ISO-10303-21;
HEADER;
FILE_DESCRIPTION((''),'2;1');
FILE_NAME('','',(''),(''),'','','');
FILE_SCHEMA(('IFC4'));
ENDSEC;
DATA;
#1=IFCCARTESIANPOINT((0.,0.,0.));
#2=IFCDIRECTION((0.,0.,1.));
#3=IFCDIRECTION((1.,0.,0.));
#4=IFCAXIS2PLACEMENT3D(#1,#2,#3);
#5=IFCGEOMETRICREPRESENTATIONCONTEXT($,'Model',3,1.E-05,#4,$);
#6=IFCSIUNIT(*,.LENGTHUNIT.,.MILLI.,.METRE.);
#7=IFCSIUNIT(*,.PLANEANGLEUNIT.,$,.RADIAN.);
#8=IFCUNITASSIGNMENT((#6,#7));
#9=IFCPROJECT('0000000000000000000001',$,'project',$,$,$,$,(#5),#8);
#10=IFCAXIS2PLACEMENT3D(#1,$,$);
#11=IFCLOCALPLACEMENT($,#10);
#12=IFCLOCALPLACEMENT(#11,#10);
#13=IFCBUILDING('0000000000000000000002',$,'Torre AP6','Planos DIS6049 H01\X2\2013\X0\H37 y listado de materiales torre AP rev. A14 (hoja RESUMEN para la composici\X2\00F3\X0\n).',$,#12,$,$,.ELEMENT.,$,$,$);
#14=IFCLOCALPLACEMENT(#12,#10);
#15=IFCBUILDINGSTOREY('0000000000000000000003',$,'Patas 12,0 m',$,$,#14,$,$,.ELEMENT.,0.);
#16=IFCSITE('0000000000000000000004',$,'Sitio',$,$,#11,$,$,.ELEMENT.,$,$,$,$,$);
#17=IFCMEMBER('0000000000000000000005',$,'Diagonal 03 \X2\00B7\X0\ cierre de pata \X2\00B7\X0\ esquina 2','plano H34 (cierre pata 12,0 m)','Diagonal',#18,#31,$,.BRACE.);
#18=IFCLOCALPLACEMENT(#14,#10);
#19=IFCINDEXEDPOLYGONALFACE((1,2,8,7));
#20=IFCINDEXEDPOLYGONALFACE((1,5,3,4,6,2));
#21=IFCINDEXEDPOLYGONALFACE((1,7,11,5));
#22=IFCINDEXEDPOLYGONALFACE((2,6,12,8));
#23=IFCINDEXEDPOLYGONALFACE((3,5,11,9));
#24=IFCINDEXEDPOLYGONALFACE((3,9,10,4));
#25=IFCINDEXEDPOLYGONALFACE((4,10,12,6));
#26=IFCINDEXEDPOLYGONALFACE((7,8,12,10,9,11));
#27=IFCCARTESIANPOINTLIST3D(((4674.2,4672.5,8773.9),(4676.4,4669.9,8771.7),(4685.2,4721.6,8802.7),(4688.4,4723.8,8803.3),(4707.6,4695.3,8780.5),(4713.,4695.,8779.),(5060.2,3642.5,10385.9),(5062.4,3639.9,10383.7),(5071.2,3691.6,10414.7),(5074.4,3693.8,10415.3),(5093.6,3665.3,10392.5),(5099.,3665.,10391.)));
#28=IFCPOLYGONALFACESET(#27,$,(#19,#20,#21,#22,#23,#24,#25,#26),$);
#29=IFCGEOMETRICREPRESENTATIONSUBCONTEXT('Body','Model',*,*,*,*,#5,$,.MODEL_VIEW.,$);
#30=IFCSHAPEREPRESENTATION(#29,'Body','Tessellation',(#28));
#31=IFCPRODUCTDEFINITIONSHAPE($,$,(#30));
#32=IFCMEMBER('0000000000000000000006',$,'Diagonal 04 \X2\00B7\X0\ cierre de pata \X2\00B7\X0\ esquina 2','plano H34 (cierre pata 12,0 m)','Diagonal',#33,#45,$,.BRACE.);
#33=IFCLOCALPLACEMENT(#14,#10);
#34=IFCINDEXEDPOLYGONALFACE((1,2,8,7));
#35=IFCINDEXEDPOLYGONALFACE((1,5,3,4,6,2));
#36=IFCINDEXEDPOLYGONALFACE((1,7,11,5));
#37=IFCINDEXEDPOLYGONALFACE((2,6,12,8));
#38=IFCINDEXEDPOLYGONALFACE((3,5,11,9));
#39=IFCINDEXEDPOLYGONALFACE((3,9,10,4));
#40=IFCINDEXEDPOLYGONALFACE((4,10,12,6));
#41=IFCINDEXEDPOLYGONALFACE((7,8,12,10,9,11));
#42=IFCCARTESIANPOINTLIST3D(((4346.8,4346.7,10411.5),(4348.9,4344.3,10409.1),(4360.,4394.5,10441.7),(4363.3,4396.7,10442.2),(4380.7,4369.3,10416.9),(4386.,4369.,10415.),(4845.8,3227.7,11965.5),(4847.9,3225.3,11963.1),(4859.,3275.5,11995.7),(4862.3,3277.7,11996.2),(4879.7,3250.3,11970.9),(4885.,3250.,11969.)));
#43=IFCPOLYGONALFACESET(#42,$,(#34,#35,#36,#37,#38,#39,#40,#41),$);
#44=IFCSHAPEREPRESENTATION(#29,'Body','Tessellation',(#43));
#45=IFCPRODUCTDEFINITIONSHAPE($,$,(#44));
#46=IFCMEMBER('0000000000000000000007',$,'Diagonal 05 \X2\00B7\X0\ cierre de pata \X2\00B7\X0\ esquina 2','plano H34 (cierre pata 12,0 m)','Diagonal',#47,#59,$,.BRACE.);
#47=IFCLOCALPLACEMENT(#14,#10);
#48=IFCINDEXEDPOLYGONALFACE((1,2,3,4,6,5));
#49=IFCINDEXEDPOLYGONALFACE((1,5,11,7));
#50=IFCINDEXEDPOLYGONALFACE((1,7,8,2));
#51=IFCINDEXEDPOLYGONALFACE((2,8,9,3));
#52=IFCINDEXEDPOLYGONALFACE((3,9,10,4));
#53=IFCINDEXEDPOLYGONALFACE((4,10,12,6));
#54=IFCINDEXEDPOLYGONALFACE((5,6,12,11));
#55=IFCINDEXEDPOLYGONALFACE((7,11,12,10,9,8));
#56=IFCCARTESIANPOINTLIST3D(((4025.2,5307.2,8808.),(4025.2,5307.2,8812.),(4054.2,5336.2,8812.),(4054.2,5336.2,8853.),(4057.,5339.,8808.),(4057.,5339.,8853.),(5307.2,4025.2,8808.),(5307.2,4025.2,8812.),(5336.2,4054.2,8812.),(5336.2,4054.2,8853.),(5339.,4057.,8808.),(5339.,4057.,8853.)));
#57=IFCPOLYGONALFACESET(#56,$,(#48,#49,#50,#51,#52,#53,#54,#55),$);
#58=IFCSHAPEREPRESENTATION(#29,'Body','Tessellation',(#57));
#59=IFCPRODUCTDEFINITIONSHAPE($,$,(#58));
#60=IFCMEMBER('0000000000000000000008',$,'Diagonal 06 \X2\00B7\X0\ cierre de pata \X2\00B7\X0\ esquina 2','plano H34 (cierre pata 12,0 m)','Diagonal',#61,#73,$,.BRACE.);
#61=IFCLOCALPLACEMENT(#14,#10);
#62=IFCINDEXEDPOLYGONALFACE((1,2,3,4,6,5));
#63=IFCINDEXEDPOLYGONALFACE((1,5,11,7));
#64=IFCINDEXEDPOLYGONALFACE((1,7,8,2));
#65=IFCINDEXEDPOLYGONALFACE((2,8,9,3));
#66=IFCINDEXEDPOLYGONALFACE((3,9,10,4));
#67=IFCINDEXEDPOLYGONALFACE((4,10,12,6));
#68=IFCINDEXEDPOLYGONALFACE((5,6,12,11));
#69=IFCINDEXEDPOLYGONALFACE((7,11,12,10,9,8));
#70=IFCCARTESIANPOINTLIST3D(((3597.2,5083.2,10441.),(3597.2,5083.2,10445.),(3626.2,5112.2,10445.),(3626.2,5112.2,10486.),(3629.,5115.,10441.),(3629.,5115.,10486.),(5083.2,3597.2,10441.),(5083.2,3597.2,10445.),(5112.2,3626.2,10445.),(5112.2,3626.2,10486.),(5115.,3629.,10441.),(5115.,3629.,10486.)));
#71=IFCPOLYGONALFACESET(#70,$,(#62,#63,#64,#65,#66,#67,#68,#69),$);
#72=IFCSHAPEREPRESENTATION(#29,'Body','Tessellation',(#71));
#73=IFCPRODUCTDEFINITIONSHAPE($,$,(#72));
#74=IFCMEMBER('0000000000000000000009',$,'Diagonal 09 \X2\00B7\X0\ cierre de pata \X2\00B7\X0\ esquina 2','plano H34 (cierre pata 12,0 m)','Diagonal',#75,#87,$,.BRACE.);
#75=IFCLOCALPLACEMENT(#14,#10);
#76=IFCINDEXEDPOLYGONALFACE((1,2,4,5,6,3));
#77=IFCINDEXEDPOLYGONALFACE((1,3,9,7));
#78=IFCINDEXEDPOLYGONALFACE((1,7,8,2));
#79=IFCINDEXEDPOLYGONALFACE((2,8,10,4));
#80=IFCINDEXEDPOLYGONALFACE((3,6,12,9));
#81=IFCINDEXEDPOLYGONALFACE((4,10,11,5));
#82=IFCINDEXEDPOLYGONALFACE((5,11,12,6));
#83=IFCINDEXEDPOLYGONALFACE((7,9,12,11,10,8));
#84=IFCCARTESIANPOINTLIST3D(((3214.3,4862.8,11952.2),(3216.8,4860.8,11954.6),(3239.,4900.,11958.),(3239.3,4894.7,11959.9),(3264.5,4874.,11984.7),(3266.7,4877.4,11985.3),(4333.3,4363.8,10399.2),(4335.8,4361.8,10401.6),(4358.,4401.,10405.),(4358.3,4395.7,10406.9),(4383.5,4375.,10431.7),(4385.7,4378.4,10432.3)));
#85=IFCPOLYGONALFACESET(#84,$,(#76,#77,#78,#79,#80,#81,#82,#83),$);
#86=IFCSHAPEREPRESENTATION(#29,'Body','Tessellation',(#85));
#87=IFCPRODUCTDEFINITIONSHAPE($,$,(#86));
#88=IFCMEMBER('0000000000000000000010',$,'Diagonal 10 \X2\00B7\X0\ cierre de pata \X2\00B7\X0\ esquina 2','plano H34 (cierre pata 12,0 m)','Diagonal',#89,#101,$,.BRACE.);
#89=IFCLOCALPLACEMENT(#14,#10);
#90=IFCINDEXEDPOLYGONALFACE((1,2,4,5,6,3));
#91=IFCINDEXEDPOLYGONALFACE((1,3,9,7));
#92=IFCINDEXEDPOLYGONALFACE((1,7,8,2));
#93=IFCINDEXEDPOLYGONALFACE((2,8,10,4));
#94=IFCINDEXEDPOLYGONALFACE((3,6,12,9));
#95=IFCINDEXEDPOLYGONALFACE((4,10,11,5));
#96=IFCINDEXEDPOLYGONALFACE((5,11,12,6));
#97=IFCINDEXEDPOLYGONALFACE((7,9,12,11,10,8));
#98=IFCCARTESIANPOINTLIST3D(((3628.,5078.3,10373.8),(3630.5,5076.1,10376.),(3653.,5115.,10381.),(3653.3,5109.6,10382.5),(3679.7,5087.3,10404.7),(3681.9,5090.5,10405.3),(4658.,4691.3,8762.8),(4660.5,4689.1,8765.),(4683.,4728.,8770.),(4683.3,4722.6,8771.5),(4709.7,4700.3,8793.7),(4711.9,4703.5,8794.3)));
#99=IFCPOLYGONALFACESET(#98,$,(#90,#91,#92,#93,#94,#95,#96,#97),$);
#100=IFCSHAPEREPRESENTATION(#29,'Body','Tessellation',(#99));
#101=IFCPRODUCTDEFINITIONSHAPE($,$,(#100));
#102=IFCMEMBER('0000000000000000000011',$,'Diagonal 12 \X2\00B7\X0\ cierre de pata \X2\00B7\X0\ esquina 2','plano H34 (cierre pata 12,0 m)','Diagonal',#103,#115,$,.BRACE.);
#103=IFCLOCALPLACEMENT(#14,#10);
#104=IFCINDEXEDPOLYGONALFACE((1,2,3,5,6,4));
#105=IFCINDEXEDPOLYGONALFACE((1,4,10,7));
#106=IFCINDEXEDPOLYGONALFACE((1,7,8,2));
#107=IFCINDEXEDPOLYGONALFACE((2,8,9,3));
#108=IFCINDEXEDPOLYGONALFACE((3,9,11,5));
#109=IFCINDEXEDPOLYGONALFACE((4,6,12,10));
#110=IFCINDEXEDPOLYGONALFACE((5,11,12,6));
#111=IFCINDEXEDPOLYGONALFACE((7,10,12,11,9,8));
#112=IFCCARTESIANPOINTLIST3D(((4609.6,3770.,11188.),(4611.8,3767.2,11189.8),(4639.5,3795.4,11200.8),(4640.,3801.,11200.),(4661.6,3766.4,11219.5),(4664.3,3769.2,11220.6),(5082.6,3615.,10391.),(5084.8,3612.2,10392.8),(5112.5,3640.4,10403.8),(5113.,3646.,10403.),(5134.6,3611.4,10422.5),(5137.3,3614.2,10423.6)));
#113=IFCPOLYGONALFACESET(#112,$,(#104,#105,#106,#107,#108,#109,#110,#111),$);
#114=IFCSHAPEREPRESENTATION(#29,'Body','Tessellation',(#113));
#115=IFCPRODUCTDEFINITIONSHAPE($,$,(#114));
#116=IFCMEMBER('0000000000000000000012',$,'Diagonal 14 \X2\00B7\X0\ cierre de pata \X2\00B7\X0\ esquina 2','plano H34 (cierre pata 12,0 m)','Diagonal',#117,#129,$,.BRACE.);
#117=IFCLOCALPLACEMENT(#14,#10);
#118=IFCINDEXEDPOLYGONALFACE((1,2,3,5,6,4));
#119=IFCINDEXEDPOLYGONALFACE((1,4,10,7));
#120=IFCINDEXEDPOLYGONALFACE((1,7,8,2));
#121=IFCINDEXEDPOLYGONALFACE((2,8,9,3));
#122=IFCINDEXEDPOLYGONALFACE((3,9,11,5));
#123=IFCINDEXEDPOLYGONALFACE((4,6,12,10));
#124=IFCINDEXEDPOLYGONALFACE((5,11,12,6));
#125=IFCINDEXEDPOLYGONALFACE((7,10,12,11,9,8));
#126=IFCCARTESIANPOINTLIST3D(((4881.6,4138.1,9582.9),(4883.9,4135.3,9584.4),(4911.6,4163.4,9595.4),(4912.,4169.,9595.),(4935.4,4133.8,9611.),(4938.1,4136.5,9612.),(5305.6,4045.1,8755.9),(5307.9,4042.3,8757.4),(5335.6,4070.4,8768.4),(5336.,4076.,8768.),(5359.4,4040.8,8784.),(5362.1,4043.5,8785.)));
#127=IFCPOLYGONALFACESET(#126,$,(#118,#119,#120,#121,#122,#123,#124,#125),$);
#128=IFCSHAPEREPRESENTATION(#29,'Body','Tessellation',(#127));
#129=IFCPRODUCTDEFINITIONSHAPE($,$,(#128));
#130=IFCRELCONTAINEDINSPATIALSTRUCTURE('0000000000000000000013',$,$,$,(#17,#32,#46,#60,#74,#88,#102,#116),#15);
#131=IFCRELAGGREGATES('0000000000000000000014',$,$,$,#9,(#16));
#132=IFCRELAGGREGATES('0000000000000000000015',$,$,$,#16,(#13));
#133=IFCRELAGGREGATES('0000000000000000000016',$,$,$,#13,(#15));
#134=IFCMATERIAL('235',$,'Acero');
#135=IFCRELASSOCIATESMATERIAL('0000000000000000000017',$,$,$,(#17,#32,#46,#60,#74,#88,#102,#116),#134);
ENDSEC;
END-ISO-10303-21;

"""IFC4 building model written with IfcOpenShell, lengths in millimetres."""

from ifc_helpers import new_model, si_unit, frame, frame_2d, origin, origin_with_axes, place, context, subcontext, project, spatial, l_section, extrude, material, element, save


model = new_model("IFC4")

# Units and contexts
model_context = context("Model", 3, precision=1e-05, world=origin_with_axes())
body_context = subcontext(model_context, "Body", "Model", "MODEL_VIEW")
ifc_project = project(units=[si_unit("LENGTHUNIT", "METRE", prefix="MILLI"), si_unit("PLANEANGLEUNIT", "RADIAN")], contexts=[model_context])

# Site, building, storey
site_placement = place(None, origin())
site = spatial("IfcSite", under=ifc_project, at=site_placement, Name="Sitio", CompositionType="ELEMENT")
building_placement = place(site_placement, origin())
building = spatial("IfcBuilding", under=site, at=building_placement, Name="Torre AP6", Description="Planos DIS6049 H01–H37 y listado de materiales torre AP rev. A14 (hoja RESUMEN para la composición).", CompositionType="ELEMENT")
storey_placement = place(building_placement, origin())
storey = spatial("IfcBuildingStorey", under=building, at=storey_placement, Name="Patas 12,0 m", CompositionType="ELEMENT", Elevation=0.0)

# Members
ifc_material_1 = material(Name="235", Category="Acero")
member_1_placement = place(storey_placement, frame((5099.0, 3665.0, 10391.0), z_axis=(-0.197794, 0.527793, -0.826022), x_axis=(-0.814212, -0.557689, -0.161373)))
element("IfcMember", 1, at=member_1_placement, inside=storey, material=ifc_material_1, Name="Diagonal 03 · cierre de pata · esquina 2", Description="plano H34 (cierre pata 12,0 m)", ObjectType="Diagonal", PredefinedType="BRACE", context=body_context, shape_type="SweptSolid", body=[
    extrude(l_section(Depth=45.0, Width=45.0, Thickness=4.0, at=frame_2d((22.5, 22.5))), None, (0.0, 0.0, 1.0), 1951.5),
])
member_2_placement = place(storey_placement, frame((4885.0, 3250.0, 11969.0), z_axis=(-0.252159, 0.565463, -0.785281), x_axis=(-0.82519, -0.549521, -0.130724)))
element("IfcMember", 2, at=member_2_placement, inside=storey, material=ifc_material_1, Name="Diagonal 04 · cierre de pata · esquina 2", Description="plano H34 (cierre pata 12,0 m)", ObjectType="Diagonal", PredefinedType="BRACE", context=body_context, shape_type="SweptSolid", body=[
    extrude(l_section(Depth=45.0, Width=45.0, Thickness=4.0, at=frame_2d((22.5, 22.5))), None, (0.0, 0.0, 1.0), 1978.9),
])
member_3_placement = place(storey_placement, frame((5339.0, 4057.0, 8808.0), z_axis=(-0.707107, 0.707107, 0.0), x_axis=(-0.707107, -0.707107, 0.0)))
element("IfcMember", 3, at=member_3_placement, inside=storey, material=ifc_material_1, Name="Diagonal 05 · cierre de pata · esquina 2", Description="plano H34 (cierre pata 12,0 m)", ObjectType="Diagonal", PredefinedType="BRACE", context=body_context, shape_type="SweptSolid", body=[
    extrude(l_section(Depth=45.0, Width=45.0, Thickness=4.0, at=frame_2d((22.5, 22.5))), None, (0.0, 0.0, 1.0), 1813.0),
])
member_4_placement = place(storey_placement, frame((5115.0, 3629.0, 10441.0), z_axis=(-0.707107, 0.707107, 0.0), x_axis=(-0.707107, -0.707107, 0.0)))
element("IfcMember", 4, at=member_4_placement, inside=storey, material=ifc_material_1, Name="Diagonal 06 · cierre de pata · esquina 2", Description="plano H34 (cierre pata 12,0 m)", ObjectType="Diagonal", PredefinedType="BRACE", context=body_context, shape_type="SweptSolid", body=[
    extrude(l_section(Depth=45.0, Width=45.0, Thickness=4.0, at=frame_2d((22.5, 22.5))), None, (0.0, 0.0, 1.0), 2101.5),
])
member_5_placement = place(storey_placement, frame((4358.0, 4401.0, 10405.0), z_axis=(-0.565688, 0.252259, 0.785088), x_axis=(-0.547962, -0.826453, -0.129279)))
element("IfcMember", 5, at=member_5_placement, inside=storey, material=ifc_material_1, Name="Diagonal 09 · cierre de pata · esquina 2", Description="plano H34 (cierre pata 12,0 m)", ObjectType="Diagonal", PredefinedType="BRACE", context=body_context, shape_type="SweptSolid", body=[
    extrude(l_section(Depth=45.0, Width=45.0, Thickness=4.0, at=frame_2d((22.5, 22.5))), None, (0.0, 0.0, 1.0), 1978.1),
])
member_6_placement = place(storey_placement, frame((4683.0, 4728.0, 8770.0), z_axis=(-0.527963, 0.198371, 0.825775), x_axis=(-0.556162, -0.815593, -0.15966)))
element("IfcMember", 6, at=member_6_placement, inside=storey, material=ifc_material_1, Name="Diagonal 10 · cierre de pata · esquina 2", Description="plano H34 (cierre pata 12,0 m)", ObjectType="Diagonal", PredefinedType="BRACE", context=body_context, shape_type="SweptSolid", body=[
    extrude(l_section(Depth=45.0, Width=45.0, Thickness=4.0, at=frame_2d((22.5, 22.5))), None, (0.0, 0.0, 1.0), 1950.9),
])
member_7_placement = place(storey_placement, frame((5113.0, 3646.0, 10403.0), z_axis=(-0.503373, 0.164953, 0.848178), x_axis=(-0.674878, -0.688043, -0.266714)))
element("IfcMember", 7, at=member_7_placement, inside=storey, material=ifc_material_1, Name="Diagonal 12 · cierre de pata · esquina 2", Description="plano H34 (cierre pata 12,0 m)", ObjectType="Diagonal", PredefinedType="BRACE", context=body_context, shape_type="SweptSolid", body=[
    extrude(l_section(Depth=45.0, Width=45.0, Thickness=4.0, at=frame_2d((22.5, 22.5))), None, (0.0, 0.0, 1.0), 939.7),
])
member_8_placement = place(storey_placement, frame((5336.0, 4076.0, 8768.0), z_axis=(-0.453962, 0.099572, 0.88544), x_axis=(-0.67623, -0.685585, -0.269603)))
element("IfcMember", 8, at=member_8_placement, inside=storey, material=ifc_material_1, Name="Diagonal 14 · cierre de pata · esquina 2", Description="plano H34 (cierre pata 12,0 m)", ObjectType="Diagonal", PredefinedType="BRACE", context=body_context, shape_type="SweptSolid", body=[
    extrude(l_section(Depth=45.0, Width=45.0, Thickness=4.0, at=frame_2d((22.5, 22.5))), None, (0.0, 0.0, 1.0), 934.0),
])

save(model, "model.ifc")
